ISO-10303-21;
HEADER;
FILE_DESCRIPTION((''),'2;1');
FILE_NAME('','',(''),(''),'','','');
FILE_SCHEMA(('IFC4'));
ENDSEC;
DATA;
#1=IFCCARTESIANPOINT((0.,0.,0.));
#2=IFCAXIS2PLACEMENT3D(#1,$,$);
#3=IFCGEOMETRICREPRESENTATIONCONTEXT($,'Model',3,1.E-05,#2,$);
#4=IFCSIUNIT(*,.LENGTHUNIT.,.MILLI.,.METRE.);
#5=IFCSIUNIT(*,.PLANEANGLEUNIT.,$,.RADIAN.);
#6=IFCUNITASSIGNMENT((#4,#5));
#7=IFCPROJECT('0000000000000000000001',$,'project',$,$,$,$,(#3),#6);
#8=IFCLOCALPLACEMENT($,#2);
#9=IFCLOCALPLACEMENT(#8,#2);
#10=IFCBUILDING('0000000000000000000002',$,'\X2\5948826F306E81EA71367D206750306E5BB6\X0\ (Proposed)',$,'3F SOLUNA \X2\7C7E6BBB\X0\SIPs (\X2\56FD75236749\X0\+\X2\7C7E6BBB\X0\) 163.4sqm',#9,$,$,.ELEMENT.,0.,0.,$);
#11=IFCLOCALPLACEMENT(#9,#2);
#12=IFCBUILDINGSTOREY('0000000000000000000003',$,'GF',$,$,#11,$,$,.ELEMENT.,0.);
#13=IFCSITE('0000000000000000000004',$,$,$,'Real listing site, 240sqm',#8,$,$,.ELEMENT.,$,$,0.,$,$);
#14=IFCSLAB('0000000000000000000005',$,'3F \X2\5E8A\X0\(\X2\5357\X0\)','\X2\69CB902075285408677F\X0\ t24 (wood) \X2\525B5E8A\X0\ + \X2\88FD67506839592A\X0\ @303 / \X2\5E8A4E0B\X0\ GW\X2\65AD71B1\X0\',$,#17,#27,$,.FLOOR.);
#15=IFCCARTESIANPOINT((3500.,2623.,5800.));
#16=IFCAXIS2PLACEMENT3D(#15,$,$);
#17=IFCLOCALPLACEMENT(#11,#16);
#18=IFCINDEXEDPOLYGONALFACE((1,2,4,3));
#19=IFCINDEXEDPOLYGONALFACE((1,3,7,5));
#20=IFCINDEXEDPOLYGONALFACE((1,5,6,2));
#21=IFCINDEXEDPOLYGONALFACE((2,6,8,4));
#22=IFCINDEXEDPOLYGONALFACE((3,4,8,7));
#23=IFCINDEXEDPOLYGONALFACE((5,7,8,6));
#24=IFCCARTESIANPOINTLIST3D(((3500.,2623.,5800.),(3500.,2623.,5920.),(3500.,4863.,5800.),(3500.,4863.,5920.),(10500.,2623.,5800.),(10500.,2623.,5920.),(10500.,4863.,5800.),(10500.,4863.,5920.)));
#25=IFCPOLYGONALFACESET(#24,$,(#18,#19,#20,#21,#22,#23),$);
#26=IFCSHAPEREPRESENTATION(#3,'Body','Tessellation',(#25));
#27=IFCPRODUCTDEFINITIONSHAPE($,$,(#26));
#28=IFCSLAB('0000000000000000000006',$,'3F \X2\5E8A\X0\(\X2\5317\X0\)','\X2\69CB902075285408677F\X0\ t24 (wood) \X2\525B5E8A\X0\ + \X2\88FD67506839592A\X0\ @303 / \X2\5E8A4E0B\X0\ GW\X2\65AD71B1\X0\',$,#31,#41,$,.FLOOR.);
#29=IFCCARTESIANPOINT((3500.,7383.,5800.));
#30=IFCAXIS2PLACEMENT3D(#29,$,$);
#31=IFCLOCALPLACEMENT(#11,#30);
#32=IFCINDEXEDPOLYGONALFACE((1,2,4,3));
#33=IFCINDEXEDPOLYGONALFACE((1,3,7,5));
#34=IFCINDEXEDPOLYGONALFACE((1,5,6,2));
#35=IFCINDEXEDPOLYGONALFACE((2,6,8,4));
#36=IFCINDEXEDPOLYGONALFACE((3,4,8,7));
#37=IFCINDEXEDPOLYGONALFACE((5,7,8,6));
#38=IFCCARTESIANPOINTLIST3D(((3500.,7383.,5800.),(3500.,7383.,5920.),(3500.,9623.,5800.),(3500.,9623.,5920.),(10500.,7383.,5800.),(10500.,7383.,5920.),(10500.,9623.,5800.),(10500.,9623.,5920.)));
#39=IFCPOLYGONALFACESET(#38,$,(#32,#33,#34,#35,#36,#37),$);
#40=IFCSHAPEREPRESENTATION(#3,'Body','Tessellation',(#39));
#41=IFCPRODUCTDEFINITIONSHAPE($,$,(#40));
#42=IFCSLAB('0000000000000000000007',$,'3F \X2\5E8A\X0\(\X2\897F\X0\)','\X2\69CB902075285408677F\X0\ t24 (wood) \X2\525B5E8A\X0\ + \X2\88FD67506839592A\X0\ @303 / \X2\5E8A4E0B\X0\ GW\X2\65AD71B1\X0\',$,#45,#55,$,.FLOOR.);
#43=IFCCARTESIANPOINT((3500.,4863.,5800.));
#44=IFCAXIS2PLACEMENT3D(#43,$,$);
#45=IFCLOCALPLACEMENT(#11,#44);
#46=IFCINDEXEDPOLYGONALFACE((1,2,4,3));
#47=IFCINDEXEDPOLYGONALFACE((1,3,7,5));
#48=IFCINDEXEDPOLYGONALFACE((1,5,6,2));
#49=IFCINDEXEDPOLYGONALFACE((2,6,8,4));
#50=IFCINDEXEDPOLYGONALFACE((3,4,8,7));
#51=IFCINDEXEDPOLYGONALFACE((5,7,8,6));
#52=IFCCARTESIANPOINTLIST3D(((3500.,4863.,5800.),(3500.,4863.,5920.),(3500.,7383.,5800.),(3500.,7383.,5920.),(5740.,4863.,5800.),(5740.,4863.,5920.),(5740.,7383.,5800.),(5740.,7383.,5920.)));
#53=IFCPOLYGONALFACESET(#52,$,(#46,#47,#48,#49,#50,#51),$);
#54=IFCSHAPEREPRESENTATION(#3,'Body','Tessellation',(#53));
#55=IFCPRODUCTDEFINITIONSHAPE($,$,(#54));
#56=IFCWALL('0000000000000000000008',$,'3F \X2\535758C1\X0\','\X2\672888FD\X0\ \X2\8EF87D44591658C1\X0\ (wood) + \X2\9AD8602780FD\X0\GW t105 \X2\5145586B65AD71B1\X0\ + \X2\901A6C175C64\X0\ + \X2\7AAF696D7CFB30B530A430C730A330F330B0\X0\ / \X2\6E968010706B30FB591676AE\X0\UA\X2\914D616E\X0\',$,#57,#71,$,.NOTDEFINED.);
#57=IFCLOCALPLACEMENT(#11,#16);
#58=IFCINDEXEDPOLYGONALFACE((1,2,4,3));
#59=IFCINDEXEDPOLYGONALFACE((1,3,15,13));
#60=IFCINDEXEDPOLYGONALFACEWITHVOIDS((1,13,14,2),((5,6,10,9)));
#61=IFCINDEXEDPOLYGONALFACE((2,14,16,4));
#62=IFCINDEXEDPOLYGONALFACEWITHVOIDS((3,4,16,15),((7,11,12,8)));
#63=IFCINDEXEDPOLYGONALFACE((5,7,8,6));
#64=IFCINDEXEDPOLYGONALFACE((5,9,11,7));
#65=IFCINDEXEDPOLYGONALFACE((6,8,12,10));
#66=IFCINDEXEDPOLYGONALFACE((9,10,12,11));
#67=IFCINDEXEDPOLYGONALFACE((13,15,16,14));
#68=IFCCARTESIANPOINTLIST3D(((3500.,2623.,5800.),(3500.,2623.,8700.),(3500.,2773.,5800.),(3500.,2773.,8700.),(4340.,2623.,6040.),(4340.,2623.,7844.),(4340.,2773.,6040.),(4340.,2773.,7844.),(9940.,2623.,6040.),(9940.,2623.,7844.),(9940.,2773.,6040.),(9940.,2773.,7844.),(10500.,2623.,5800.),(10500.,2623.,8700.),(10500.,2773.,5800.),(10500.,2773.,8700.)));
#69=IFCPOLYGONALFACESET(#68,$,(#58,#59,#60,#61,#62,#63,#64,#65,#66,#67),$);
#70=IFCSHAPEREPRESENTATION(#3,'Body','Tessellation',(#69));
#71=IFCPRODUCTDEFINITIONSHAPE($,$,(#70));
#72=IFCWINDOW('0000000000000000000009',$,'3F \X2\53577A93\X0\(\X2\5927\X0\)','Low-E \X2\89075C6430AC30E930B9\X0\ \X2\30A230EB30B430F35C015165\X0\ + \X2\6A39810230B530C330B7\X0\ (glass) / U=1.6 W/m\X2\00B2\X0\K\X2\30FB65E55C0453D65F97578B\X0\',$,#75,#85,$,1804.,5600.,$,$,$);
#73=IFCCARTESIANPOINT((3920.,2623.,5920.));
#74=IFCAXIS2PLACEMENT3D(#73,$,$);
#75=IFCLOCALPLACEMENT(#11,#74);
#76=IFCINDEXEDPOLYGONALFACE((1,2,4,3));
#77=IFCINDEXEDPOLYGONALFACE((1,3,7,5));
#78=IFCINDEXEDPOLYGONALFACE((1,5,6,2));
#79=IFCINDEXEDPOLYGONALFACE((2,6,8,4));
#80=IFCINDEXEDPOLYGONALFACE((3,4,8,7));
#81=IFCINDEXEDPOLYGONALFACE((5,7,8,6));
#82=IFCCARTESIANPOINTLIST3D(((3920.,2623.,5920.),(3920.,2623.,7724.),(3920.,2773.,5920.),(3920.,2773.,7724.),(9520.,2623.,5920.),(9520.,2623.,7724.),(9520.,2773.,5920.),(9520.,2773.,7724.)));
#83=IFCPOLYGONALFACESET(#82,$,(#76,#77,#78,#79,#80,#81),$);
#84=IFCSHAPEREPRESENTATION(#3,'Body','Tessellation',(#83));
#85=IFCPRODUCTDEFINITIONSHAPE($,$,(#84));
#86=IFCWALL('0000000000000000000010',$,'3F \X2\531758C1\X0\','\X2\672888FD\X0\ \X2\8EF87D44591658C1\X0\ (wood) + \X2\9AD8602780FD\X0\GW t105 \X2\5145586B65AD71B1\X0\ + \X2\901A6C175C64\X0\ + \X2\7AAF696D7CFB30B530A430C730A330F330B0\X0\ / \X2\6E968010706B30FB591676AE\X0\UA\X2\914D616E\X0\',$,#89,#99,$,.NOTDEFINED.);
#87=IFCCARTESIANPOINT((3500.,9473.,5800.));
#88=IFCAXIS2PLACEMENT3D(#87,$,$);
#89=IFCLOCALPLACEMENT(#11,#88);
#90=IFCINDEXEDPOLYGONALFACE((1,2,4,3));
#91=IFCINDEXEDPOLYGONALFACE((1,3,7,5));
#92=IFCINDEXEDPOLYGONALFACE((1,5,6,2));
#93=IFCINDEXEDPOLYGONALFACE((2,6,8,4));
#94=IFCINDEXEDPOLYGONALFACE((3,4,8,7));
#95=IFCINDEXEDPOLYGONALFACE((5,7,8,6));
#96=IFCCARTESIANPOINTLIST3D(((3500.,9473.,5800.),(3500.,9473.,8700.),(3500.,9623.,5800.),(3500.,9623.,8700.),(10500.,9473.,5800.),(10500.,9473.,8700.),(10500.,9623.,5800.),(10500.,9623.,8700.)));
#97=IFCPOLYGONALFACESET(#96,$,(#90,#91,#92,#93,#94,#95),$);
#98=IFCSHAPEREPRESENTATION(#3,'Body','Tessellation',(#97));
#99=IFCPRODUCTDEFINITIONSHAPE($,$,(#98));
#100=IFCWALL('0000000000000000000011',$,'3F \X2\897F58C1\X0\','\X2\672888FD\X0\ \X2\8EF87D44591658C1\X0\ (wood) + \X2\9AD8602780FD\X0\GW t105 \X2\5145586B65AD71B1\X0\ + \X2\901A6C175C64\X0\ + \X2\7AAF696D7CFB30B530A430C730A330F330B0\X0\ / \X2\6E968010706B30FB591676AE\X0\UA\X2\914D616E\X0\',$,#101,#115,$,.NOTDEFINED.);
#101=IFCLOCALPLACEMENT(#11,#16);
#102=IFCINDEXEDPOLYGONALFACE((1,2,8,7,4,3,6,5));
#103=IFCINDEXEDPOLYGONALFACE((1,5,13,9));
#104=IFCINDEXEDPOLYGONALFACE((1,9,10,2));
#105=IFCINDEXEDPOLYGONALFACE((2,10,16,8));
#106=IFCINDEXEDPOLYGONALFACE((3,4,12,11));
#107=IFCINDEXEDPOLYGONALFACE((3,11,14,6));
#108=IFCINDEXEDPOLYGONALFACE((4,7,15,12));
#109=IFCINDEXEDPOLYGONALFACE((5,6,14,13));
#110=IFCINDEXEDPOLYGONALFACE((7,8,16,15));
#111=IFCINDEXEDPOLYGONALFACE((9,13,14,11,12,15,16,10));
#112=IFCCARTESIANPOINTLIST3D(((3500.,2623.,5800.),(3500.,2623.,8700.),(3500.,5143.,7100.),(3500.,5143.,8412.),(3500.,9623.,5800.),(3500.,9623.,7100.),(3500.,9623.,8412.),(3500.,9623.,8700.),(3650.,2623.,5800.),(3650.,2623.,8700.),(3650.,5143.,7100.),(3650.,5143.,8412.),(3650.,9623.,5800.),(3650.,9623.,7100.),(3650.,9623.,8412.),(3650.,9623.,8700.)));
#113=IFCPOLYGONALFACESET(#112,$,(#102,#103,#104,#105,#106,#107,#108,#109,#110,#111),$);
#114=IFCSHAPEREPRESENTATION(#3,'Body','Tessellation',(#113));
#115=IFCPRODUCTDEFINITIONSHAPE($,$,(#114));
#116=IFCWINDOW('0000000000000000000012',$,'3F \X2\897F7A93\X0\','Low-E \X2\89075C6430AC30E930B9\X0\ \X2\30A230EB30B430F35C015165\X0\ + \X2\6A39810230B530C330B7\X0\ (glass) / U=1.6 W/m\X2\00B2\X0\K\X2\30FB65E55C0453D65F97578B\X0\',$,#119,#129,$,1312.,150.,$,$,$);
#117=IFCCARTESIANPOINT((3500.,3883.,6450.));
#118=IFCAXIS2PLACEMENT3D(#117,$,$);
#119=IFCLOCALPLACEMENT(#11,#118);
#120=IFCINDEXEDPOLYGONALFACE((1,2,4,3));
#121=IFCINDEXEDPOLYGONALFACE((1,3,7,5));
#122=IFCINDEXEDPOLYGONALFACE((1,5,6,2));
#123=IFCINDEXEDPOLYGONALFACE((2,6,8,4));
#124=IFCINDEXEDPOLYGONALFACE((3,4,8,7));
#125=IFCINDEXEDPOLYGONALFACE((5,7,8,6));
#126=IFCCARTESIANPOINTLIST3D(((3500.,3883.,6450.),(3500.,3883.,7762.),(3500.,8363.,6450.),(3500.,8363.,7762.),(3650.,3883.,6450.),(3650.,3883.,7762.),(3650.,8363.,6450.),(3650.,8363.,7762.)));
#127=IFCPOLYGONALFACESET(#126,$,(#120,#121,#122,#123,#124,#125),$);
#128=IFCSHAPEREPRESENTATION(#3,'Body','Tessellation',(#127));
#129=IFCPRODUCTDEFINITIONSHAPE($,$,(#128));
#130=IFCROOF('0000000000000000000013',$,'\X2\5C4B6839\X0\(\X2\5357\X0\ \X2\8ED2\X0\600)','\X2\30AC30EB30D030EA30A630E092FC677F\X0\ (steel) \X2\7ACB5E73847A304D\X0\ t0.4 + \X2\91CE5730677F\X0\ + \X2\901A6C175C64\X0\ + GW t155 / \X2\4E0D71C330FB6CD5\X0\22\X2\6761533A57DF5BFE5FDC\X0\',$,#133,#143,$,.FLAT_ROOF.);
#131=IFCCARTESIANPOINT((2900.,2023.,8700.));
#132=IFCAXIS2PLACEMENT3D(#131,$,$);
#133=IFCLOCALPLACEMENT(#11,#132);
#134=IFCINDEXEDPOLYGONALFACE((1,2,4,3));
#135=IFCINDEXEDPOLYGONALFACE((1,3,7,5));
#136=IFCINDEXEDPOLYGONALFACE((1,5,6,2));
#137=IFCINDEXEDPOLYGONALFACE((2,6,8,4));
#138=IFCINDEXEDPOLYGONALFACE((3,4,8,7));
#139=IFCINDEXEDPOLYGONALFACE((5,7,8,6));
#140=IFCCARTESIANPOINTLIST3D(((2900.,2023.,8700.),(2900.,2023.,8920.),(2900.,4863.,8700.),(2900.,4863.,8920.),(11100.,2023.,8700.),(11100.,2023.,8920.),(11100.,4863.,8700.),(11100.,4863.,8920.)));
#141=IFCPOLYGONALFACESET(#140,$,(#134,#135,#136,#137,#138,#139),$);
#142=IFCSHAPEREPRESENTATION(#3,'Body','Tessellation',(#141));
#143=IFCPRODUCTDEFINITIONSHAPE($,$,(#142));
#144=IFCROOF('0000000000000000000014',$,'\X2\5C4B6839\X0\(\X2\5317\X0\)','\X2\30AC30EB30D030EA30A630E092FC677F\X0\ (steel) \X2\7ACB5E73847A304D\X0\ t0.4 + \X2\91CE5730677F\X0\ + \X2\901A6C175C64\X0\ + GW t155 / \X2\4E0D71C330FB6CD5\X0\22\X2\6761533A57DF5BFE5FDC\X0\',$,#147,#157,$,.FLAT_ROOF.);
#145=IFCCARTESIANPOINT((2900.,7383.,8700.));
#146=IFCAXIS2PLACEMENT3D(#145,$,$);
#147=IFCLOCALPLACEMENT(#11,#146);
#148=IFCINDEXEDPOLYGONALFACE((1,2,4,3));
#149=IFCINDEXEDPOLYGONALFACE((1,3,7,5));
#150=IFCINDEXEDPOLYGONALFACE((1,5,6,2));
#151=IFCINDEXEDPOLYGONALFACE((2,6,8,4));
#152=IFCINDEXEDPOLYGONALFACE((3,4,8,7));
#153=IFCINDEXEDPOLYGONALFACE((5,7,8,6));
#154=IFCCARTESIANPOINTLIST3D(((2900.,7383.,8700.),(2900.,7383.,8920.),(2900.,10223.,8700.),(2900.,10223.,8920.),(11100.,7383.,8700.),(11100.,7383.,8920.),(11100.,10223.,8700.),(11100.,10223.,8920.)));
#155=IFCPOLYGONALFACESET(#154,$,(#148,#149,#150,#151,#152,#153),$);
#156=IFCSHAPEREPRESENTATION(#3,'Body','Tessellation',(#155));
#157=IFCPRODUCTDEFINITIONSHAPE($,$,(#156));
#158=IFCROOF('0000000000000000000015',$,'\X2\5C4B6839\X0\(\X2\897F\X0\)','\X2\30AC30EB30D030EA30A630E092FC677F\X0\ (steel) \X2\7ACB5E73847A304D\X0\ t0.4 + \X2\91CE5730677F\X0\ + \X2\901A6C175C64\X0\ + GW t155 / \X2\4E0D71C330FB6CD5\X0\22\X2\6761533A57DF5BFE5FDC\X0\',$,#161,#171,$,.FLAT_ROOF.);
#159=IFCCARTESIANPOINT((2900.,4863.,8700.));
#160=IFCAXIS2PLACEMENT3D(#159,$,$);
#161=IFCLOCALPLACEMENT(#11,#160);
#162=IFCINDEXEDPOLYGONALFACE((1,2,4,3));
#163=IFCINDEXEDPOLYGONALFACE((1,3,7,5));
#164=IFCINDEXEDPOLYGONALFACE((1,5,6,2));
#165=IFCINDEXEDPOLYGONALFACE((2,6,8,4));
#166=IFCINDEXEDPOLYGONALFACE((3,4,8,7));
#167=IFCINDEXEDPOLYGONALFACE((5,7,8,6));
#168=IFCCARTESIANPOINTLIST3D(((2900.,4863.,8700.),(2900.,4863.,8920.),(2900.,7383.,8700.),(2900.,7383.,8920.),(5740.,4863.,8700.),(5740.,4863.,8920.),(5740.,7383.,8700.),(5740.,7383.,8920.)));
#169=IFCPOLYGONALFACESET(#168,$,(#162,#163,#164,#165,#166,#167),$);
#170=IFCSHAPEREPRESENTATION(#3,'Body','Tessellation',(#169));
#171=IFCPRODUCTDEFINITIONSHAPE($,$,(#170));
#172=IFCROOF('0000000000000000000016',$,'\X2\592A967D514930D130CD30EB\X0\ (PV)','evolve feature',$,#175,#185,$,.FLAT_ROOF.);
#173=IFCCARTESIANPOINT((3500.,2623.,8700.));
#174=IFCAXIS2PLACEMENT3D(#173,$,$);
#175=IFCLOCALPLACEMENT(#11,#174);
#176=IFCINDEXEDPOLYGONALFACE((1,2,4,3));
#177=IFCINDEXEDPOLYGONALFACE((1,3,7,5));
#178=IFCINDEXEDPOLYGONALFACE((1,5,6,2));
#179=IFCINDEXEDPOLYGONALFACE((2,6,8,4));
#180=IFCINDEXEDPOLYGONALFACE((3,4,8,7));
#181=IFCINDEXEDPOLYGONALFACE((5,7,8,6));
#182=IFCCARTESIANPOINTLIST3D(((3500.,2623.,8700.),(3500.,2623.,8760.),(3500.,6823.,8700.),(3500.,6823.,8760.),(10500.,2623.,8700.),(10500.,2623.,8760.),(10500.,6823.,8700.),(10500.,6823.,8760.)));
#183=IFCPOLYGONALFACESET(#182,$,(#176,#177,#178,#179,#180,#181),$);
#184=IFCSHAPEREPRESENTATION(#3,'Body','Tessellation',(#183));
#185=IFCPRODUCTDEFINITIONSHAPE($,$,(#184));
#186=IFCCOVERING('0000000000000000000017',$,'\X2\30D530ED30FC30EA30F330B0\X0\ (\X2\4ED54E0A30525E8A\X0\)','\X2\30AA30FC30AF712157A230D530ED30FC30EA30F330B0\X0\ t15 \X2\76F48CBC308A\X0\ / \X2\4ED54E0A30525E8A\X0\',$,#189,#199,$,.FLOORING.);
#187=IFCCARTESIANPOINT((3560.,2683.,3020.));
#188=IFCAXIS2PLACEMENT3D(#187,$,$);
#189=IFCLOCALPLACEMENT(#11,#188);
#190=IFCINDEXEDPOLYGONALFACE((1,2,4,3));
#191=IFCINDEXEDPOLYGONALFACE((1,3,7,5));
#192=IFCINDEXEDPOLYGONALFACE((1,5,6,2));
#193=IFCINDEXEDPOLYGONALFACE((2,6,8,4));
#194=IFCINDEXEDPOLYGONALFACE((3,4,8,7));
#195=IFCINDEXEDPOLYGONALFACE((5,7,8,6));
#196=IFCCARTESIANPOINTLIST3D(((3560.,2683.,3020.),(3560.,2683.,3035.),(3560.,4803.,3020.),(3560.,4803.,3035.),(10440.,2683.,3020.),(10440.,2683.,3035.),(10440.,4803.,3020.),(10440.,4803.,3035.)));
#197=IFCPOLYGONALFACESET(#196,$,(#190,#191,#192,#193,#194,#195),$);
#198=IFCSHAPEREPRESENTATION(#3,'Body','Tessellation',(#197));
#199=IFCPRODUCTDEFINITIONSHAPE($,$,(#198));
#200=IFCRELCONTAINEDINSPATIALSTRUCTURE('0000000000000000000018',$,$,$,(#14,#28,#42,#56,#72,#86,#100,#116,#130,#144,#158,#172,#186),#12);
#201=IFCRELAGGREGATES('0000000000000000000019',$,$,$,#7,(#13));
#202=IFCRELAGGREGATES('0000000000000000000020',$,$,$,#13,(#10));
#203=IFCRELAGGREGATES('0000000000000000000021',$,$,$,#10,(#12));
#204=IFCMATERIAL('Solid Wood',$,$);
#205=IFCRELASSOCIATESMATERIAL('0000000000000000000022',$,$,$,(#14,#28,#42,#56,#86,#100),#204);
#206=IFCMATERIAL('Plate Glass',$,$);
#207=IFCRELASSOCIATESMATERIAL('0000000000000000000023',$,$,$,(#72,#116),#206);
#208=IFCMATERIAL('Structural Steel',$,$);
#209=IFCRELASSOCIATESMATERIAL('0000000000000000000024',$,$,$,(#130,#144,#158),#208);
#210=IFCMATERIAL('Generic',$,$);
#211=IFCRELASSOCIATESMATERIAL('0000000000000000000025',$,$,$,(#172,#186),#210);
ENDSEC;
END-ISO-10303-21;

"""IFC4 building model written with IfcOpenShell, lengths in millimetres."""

from ifc_helpers import new_model, si_unit, frame, frame_2d, origin, place, context, project, spatial, rectangle, extrude, material, element, fill, save


model = new_model("IFC4")

# Units and contexts
model_context = context("Model", 3, precision=1e-05, world=origin())
ifc_project = project(units=[si_unit("LENGTHUNIT", "METRE", prefix="MILLI"), si_unit("PLANEANGLEUNIT", "RADIAN")], contexts=[model_context])

# Site, building, storey
site_placement = place(None, origin())
site = spatial("IfcSite", under=ifc_project, at=site_placement, ObjectType="Real listing site, 240sqm", CompositionType="ELEMENT", RefElevation=0.0)
building_placement = place(site_placement, origin())
building = spatial("IfcBuilding", under=site, at=building_placement, Name="奈良の自然素材の家 (Proposed)", ObjectType="3F SOLUNA 籾殻SIPs (国産杉+籾殻) 163.4sqm", CompositionType="ELEMENT", ElevationOfRefHeight=0.0, ElevationOfTerrain=0.0)
storey_placement = place(building_placement, origin())
storey = spatial("IfcBuildingStorey", under=building, at=storey_placement, Name="GF", CompositionType="ELEMENT", Elevation=0.0)

# Slabs
ifc_material_1 = material(Name="Solid Wood")
slab_1_placement = place(storey_placement, frame((3500.0, 2623.0, 5800.0)))
element("IfcSlab", 1, at=slab_1_placement, inside=storey, material=ifc_material_1, Name="3F 床(南)", Description="構造用合板 t24 (wood) 剛床 + 製材根太 @303 / 床下 GW断熱", PredefinedType="FLOOR", context=model_context, shape_type="SweptSolid", body=[
    extrude(rectangle(XDim=7000.0, YDim=2240.0, at=frame_2d((3500.0, 1120.0))), frame((3500.0, 2623.0, 5800.0)), (0.0, 0.0, 1.0), 120.0),
])
slab_2_placement = place(storey_placement, frame((3500.0, 7383.0, 5800.0)))
element("IfcSlab", 2, at=slab_2_placement, inside=storey, material=ifc_material_1, Name="3F 床(北)", Description="構造用合板 t24 (wood) 剛床 + 製材根太 @303 / 床下 GW断熱", PredefinedType="FLOOR", context=model_context, shape_type="SweptSolid", body=[
    extrude(rectangle(XDim=7000.0, YDim=2240.0, at=frame_2d((3500.0, 1120.0))), frame((3500.0, 7383.0, 5800.0)), (0.0, 0.0, 1.0), 120.0),
])
slab_3_placement = place(storey_placement, frame((3500.0, 4863.0, 5800.0)))
element("IfcSlab", 3, at=slab_3_placement, inside=storey, material=ifc_material_1, Name="3F 床(西)", Description="構造用合板 t24 (wood) 剛床 + 製材根太 @303 / 床下 GW断熱", PredefinedType="FLOOR", context=model_context, shape_type="SweptSolid", body=[
    extrude(rectangle(XDim=2240.0, YDim=2520.0, at=frame_2d((1120.0, 1260.0))), frame((3500.0, 4863.0, 5800.0)), (0.0, 0.0, 1.0), 120.0),
])

# Wall, opening, window
wall_1_placement = place(storey_placement, frame((3500.0, 2623.0, 5800.0)))
wall_1 = element("IfcWall", 4, at=wall_1_placement, inside=storey, material=ifc_material_1, Name="3F 南壁", Description="木製 軸組外壁 (wood) + 高性能GW t105 充填断熱 + 通気層 + 窯業系サイディング / 準耐火・外皮UA配慮", PredefinedType="NOTDEFINED", context=model_context, shape_type="SweptSolid", body=[
    extrude(rectangle(XDim=7000.0, YDim=150.0, at=frame_2d((3500.0, 75.0))), frame((3500.0, 2623.0, 5800.0)), (0.0, 0.0, 1.0), 2900.0),
])
opening_1_placement = place(storey_placement, frame((3920.0, 2623.0, 5920.0)))
opening_1 = element("IfcOpeningElement", 5, at=opening_1_placement, cuts=wall_1, PredefinedType="NOTDEFINED", context=model_context, shape_type="SweptSolid", body=[
    extrude(rectangle(XDim=5600.0, YDim=150.0, at=frame_2d((2800.0, 75.0))), frame((3920.0, 2623.0, 5920.0)), (0.0, 0.0, 1.0), 1804.0),
])
ifc_material_2 = material(Name="Plate Glass")
window_1_placement = place(storey_placement, frame((3920.0, 2623.0, 5920.0)))
window_1 = element("IfcWindow", 6, at=window_1_placement, inside=storey, material=ifc_material_2, Name="3F 南窓(大)", Description="Low-E 複層ガラス アルゴン封入 + 樹脂サッシ (glass) / U=1.6 W/m²K・日射取得型", OverallHeight=1804.0, OverallWidth=5600.0, context=model_context, shape_type="SweptSolid", body=[
    extrude(rectangle(XDim=5600.0, YDim=150.0, at=frame_2d((2800.0, 75.0))), frame((3920.0, 2623.0, 5920.0)), (0.0, 0.0, 1.0), 1804.0),
])
fill(opening_1, window_1)

# Wall
wall_2_placement = place(storey_placement, frame((3500.0, 9473.0, 5800.0)))
element("IfcWall", 7, at=wall_2_placement, inside=storey, material=ifc_material_1, Name="3F 北壁", Description="木製 軸組外壁 (wood) + 高性能GW t105 充填断熱 + 通気層 + 窯業系サイディング / 準耐火・外皮UA配慮", PredefinedType="NOTDEFINED", context=model_context, shape_type="SweptSolid", body=[
    extrude(rectangle(XDim=7000.0, YDim=150.0, at=frame_2d((3500.0, 75.0))), frame((3500.0, 9473.0, 5800.0)), (0.0, 0.0, 1.0), 2900.0),
])

# Wall, opening, window
wall_3_placement = place(storey_placement, frame((3500.0, 2623.0, 5800.0)))
wall_3 = element("IfcWall", 8, at=wall_3_placement, inside=storey, material=ifc_material_1, Name="3F 西壁", Description="木製 軸組外壁 (wood) + 高性能GW t105 充填断熱 + 通気層 + 窯業系サイディング / 準耐火・外皮UA配慮", PredefinedType="NOTDEFINED", context=model_context, shape_type="SweptSolid", body=[
    extrude(rectangle(XDim=150.0, YDim=7000.0, at=frame_2d((75.0, 3500.0))), frame((3500.0, 2623.0, 5800.0)), (0.0, 0.0, 1.0), 2900.0),
])
opening_2_placement = place(storey_placement, frame((3500.0, 3883.0, 6450.0)))
opening_2 = element("IfcOpeningElement", 9, at=opening_2_placement, cuts=wall_3, PredefinedType="NOTDEFINED", context=model_context, shape_type="SweptSolid", body=[
    extrude(rectangle(XDim=150.0, YDim=4480.0, at=frame_2d((75.0, 2240.0))), frame((3500.0, 3883.0, 6450.0)), (0.0, 0.0, 1.0), 1312.0),
])
window_2_placement = place(storey_placement, frame((3500.0, 3883.0, 6450.0)))
window_2 = element("IfcWindow", 10, at=window_2_placement, inside=storey, material=ifc_material_2, Name="3F 西窓", Description="Low-E 複層ガラス アルゴン封入 + 樹脂サッシ (glass) / U=1.6 W/m²K・日射取得型", OverallHeight=1312.0, OverallWidth=150.0, context=model_context, shape_type="SweptSolid", body=[
    extrude(rectangle(XDim=150.0, YDim=4480.0, at=frame_2d((75.0, 2240.0))), frame((3500.0, 3883.0, 6450.0)), (0.0, 0.0, 1.0), 1312.0),
])
fill(opening_2, window_2)

# Roofs
ifc_material_3 = material(Name="Structural Steel")
roof_1_placement = place(storey_placement, frame((2900.0, 2023.0, 8700.0)))
element("IfcRoof", 11, at=roof_1_placement, inside=storey, material=ifc_material_3, Name="屋根(南 軒600)", Description="ガルバリウム鋼板 (steel) 立平葺き t0.4 + 野地板 + 通気層 + GW t155 / 不燃・法22条区域対応", PredefinedType="FLAT_ROOF", context=model_context, shape_type="SweptSolid", body=[
    extrude(rectangle(XDim=8200.0, YDim=2840.0, at=frame_2d((4100.0, 1420.0))), frame((2900.0, 2023.0, 8700.0)), (0.0, 0.0, 1.0), 220.0),
])
roof_2_placement = place(storey_placement, frame((2900.0, 7383.0, 8700.0)))
element("IfcRoof", 12, at=roof_2_placement, inside=storey, material=ifc_material_3, Name="屋根(北)", Description="ガルバリウム鋼板 (steel) 立平葺き t0.4 + 野地板 + 通気層 + GW t155 / 不燃・法22条区域対応", PredefinedType="FLAT_ROOF", context=model_context, shape_type="SweptSolid", body=[
    extrude(rectangle(XDim=8200.0, YDim=2840.0, at=frame_2d((4100.0, 1420.0))), frame((2900.0, 7383.0, 8700.0)), (0.0, 0.0, 1.0), 220.0),
])
roof_3_placement = place(storey_placement, frame((2900.0, 4863.0, 8700.0)))
element("IfcRoof", 13, at=roof_3_placement, inside=storey, material=ifc_material_3, Name="屋根(西)", Description="ガルバリウム鋼板 (steel) 立平葺き t0.4 + 野地板 + 通気層 + GW t155 / 不燃・法22条区域対応", PredefinedType="FLAT_ROOF", context=model_context, shape_type="SweptSolid", body=[
    extrude(rectangle(XDim=2840.0, YDim=2520.0, at=frame_2d((1420.0, 1260.0))), frame((2900.0, 4863.0, 8700.0)), (0.0, 0.0, 1.0), 220.0),
])
ifc_material_4 = material(Name="Generic")
roof_4_placement = place(storey_placement, frame((3500.0, 2623.0, 8700.0)))
element("IfcRoof", 14, at=roof_4_placement, inside=storey, material=ifc_material_4, Name="太陽光パネル (PV)", Description="evolve feature", PredefinedType="FLAT_ROOF", context=model_context, shape_type="SweptSolid", body=[
    extrude(rectangle(XDim=7000.0, YDim=4200.0, at=frame_2d((3500.0, 2100.0))), frame((3500.0, 2623.0, 8700.0)), (0.0, 0.0, 1.0), 60.0),
])

# Covering
covering_1_placement = place(storey_placement, frame((3560.0, 2683.0, 3020.0)))
element("IfcCovering", 15, at=covering_1_placement, inside=storey, material=ifc_material_4, Name="フローリング (仕上げ床)", Description="オーク無垢フローリング t15 直貼り / 仕上げ床", PredefinedType="FLOORING", context=model_context, shape_type="SweptSolid", body=[
    extrude(rectangle(XDim=6880.0, YDim=2120.0, at=frame_2d((3440.0, 1060.0))), frame((3560.0, 2683.0, 3020.0)), (0.0, 0.0, 1.0), 15.0),
])

save(model, "model.ifc")
